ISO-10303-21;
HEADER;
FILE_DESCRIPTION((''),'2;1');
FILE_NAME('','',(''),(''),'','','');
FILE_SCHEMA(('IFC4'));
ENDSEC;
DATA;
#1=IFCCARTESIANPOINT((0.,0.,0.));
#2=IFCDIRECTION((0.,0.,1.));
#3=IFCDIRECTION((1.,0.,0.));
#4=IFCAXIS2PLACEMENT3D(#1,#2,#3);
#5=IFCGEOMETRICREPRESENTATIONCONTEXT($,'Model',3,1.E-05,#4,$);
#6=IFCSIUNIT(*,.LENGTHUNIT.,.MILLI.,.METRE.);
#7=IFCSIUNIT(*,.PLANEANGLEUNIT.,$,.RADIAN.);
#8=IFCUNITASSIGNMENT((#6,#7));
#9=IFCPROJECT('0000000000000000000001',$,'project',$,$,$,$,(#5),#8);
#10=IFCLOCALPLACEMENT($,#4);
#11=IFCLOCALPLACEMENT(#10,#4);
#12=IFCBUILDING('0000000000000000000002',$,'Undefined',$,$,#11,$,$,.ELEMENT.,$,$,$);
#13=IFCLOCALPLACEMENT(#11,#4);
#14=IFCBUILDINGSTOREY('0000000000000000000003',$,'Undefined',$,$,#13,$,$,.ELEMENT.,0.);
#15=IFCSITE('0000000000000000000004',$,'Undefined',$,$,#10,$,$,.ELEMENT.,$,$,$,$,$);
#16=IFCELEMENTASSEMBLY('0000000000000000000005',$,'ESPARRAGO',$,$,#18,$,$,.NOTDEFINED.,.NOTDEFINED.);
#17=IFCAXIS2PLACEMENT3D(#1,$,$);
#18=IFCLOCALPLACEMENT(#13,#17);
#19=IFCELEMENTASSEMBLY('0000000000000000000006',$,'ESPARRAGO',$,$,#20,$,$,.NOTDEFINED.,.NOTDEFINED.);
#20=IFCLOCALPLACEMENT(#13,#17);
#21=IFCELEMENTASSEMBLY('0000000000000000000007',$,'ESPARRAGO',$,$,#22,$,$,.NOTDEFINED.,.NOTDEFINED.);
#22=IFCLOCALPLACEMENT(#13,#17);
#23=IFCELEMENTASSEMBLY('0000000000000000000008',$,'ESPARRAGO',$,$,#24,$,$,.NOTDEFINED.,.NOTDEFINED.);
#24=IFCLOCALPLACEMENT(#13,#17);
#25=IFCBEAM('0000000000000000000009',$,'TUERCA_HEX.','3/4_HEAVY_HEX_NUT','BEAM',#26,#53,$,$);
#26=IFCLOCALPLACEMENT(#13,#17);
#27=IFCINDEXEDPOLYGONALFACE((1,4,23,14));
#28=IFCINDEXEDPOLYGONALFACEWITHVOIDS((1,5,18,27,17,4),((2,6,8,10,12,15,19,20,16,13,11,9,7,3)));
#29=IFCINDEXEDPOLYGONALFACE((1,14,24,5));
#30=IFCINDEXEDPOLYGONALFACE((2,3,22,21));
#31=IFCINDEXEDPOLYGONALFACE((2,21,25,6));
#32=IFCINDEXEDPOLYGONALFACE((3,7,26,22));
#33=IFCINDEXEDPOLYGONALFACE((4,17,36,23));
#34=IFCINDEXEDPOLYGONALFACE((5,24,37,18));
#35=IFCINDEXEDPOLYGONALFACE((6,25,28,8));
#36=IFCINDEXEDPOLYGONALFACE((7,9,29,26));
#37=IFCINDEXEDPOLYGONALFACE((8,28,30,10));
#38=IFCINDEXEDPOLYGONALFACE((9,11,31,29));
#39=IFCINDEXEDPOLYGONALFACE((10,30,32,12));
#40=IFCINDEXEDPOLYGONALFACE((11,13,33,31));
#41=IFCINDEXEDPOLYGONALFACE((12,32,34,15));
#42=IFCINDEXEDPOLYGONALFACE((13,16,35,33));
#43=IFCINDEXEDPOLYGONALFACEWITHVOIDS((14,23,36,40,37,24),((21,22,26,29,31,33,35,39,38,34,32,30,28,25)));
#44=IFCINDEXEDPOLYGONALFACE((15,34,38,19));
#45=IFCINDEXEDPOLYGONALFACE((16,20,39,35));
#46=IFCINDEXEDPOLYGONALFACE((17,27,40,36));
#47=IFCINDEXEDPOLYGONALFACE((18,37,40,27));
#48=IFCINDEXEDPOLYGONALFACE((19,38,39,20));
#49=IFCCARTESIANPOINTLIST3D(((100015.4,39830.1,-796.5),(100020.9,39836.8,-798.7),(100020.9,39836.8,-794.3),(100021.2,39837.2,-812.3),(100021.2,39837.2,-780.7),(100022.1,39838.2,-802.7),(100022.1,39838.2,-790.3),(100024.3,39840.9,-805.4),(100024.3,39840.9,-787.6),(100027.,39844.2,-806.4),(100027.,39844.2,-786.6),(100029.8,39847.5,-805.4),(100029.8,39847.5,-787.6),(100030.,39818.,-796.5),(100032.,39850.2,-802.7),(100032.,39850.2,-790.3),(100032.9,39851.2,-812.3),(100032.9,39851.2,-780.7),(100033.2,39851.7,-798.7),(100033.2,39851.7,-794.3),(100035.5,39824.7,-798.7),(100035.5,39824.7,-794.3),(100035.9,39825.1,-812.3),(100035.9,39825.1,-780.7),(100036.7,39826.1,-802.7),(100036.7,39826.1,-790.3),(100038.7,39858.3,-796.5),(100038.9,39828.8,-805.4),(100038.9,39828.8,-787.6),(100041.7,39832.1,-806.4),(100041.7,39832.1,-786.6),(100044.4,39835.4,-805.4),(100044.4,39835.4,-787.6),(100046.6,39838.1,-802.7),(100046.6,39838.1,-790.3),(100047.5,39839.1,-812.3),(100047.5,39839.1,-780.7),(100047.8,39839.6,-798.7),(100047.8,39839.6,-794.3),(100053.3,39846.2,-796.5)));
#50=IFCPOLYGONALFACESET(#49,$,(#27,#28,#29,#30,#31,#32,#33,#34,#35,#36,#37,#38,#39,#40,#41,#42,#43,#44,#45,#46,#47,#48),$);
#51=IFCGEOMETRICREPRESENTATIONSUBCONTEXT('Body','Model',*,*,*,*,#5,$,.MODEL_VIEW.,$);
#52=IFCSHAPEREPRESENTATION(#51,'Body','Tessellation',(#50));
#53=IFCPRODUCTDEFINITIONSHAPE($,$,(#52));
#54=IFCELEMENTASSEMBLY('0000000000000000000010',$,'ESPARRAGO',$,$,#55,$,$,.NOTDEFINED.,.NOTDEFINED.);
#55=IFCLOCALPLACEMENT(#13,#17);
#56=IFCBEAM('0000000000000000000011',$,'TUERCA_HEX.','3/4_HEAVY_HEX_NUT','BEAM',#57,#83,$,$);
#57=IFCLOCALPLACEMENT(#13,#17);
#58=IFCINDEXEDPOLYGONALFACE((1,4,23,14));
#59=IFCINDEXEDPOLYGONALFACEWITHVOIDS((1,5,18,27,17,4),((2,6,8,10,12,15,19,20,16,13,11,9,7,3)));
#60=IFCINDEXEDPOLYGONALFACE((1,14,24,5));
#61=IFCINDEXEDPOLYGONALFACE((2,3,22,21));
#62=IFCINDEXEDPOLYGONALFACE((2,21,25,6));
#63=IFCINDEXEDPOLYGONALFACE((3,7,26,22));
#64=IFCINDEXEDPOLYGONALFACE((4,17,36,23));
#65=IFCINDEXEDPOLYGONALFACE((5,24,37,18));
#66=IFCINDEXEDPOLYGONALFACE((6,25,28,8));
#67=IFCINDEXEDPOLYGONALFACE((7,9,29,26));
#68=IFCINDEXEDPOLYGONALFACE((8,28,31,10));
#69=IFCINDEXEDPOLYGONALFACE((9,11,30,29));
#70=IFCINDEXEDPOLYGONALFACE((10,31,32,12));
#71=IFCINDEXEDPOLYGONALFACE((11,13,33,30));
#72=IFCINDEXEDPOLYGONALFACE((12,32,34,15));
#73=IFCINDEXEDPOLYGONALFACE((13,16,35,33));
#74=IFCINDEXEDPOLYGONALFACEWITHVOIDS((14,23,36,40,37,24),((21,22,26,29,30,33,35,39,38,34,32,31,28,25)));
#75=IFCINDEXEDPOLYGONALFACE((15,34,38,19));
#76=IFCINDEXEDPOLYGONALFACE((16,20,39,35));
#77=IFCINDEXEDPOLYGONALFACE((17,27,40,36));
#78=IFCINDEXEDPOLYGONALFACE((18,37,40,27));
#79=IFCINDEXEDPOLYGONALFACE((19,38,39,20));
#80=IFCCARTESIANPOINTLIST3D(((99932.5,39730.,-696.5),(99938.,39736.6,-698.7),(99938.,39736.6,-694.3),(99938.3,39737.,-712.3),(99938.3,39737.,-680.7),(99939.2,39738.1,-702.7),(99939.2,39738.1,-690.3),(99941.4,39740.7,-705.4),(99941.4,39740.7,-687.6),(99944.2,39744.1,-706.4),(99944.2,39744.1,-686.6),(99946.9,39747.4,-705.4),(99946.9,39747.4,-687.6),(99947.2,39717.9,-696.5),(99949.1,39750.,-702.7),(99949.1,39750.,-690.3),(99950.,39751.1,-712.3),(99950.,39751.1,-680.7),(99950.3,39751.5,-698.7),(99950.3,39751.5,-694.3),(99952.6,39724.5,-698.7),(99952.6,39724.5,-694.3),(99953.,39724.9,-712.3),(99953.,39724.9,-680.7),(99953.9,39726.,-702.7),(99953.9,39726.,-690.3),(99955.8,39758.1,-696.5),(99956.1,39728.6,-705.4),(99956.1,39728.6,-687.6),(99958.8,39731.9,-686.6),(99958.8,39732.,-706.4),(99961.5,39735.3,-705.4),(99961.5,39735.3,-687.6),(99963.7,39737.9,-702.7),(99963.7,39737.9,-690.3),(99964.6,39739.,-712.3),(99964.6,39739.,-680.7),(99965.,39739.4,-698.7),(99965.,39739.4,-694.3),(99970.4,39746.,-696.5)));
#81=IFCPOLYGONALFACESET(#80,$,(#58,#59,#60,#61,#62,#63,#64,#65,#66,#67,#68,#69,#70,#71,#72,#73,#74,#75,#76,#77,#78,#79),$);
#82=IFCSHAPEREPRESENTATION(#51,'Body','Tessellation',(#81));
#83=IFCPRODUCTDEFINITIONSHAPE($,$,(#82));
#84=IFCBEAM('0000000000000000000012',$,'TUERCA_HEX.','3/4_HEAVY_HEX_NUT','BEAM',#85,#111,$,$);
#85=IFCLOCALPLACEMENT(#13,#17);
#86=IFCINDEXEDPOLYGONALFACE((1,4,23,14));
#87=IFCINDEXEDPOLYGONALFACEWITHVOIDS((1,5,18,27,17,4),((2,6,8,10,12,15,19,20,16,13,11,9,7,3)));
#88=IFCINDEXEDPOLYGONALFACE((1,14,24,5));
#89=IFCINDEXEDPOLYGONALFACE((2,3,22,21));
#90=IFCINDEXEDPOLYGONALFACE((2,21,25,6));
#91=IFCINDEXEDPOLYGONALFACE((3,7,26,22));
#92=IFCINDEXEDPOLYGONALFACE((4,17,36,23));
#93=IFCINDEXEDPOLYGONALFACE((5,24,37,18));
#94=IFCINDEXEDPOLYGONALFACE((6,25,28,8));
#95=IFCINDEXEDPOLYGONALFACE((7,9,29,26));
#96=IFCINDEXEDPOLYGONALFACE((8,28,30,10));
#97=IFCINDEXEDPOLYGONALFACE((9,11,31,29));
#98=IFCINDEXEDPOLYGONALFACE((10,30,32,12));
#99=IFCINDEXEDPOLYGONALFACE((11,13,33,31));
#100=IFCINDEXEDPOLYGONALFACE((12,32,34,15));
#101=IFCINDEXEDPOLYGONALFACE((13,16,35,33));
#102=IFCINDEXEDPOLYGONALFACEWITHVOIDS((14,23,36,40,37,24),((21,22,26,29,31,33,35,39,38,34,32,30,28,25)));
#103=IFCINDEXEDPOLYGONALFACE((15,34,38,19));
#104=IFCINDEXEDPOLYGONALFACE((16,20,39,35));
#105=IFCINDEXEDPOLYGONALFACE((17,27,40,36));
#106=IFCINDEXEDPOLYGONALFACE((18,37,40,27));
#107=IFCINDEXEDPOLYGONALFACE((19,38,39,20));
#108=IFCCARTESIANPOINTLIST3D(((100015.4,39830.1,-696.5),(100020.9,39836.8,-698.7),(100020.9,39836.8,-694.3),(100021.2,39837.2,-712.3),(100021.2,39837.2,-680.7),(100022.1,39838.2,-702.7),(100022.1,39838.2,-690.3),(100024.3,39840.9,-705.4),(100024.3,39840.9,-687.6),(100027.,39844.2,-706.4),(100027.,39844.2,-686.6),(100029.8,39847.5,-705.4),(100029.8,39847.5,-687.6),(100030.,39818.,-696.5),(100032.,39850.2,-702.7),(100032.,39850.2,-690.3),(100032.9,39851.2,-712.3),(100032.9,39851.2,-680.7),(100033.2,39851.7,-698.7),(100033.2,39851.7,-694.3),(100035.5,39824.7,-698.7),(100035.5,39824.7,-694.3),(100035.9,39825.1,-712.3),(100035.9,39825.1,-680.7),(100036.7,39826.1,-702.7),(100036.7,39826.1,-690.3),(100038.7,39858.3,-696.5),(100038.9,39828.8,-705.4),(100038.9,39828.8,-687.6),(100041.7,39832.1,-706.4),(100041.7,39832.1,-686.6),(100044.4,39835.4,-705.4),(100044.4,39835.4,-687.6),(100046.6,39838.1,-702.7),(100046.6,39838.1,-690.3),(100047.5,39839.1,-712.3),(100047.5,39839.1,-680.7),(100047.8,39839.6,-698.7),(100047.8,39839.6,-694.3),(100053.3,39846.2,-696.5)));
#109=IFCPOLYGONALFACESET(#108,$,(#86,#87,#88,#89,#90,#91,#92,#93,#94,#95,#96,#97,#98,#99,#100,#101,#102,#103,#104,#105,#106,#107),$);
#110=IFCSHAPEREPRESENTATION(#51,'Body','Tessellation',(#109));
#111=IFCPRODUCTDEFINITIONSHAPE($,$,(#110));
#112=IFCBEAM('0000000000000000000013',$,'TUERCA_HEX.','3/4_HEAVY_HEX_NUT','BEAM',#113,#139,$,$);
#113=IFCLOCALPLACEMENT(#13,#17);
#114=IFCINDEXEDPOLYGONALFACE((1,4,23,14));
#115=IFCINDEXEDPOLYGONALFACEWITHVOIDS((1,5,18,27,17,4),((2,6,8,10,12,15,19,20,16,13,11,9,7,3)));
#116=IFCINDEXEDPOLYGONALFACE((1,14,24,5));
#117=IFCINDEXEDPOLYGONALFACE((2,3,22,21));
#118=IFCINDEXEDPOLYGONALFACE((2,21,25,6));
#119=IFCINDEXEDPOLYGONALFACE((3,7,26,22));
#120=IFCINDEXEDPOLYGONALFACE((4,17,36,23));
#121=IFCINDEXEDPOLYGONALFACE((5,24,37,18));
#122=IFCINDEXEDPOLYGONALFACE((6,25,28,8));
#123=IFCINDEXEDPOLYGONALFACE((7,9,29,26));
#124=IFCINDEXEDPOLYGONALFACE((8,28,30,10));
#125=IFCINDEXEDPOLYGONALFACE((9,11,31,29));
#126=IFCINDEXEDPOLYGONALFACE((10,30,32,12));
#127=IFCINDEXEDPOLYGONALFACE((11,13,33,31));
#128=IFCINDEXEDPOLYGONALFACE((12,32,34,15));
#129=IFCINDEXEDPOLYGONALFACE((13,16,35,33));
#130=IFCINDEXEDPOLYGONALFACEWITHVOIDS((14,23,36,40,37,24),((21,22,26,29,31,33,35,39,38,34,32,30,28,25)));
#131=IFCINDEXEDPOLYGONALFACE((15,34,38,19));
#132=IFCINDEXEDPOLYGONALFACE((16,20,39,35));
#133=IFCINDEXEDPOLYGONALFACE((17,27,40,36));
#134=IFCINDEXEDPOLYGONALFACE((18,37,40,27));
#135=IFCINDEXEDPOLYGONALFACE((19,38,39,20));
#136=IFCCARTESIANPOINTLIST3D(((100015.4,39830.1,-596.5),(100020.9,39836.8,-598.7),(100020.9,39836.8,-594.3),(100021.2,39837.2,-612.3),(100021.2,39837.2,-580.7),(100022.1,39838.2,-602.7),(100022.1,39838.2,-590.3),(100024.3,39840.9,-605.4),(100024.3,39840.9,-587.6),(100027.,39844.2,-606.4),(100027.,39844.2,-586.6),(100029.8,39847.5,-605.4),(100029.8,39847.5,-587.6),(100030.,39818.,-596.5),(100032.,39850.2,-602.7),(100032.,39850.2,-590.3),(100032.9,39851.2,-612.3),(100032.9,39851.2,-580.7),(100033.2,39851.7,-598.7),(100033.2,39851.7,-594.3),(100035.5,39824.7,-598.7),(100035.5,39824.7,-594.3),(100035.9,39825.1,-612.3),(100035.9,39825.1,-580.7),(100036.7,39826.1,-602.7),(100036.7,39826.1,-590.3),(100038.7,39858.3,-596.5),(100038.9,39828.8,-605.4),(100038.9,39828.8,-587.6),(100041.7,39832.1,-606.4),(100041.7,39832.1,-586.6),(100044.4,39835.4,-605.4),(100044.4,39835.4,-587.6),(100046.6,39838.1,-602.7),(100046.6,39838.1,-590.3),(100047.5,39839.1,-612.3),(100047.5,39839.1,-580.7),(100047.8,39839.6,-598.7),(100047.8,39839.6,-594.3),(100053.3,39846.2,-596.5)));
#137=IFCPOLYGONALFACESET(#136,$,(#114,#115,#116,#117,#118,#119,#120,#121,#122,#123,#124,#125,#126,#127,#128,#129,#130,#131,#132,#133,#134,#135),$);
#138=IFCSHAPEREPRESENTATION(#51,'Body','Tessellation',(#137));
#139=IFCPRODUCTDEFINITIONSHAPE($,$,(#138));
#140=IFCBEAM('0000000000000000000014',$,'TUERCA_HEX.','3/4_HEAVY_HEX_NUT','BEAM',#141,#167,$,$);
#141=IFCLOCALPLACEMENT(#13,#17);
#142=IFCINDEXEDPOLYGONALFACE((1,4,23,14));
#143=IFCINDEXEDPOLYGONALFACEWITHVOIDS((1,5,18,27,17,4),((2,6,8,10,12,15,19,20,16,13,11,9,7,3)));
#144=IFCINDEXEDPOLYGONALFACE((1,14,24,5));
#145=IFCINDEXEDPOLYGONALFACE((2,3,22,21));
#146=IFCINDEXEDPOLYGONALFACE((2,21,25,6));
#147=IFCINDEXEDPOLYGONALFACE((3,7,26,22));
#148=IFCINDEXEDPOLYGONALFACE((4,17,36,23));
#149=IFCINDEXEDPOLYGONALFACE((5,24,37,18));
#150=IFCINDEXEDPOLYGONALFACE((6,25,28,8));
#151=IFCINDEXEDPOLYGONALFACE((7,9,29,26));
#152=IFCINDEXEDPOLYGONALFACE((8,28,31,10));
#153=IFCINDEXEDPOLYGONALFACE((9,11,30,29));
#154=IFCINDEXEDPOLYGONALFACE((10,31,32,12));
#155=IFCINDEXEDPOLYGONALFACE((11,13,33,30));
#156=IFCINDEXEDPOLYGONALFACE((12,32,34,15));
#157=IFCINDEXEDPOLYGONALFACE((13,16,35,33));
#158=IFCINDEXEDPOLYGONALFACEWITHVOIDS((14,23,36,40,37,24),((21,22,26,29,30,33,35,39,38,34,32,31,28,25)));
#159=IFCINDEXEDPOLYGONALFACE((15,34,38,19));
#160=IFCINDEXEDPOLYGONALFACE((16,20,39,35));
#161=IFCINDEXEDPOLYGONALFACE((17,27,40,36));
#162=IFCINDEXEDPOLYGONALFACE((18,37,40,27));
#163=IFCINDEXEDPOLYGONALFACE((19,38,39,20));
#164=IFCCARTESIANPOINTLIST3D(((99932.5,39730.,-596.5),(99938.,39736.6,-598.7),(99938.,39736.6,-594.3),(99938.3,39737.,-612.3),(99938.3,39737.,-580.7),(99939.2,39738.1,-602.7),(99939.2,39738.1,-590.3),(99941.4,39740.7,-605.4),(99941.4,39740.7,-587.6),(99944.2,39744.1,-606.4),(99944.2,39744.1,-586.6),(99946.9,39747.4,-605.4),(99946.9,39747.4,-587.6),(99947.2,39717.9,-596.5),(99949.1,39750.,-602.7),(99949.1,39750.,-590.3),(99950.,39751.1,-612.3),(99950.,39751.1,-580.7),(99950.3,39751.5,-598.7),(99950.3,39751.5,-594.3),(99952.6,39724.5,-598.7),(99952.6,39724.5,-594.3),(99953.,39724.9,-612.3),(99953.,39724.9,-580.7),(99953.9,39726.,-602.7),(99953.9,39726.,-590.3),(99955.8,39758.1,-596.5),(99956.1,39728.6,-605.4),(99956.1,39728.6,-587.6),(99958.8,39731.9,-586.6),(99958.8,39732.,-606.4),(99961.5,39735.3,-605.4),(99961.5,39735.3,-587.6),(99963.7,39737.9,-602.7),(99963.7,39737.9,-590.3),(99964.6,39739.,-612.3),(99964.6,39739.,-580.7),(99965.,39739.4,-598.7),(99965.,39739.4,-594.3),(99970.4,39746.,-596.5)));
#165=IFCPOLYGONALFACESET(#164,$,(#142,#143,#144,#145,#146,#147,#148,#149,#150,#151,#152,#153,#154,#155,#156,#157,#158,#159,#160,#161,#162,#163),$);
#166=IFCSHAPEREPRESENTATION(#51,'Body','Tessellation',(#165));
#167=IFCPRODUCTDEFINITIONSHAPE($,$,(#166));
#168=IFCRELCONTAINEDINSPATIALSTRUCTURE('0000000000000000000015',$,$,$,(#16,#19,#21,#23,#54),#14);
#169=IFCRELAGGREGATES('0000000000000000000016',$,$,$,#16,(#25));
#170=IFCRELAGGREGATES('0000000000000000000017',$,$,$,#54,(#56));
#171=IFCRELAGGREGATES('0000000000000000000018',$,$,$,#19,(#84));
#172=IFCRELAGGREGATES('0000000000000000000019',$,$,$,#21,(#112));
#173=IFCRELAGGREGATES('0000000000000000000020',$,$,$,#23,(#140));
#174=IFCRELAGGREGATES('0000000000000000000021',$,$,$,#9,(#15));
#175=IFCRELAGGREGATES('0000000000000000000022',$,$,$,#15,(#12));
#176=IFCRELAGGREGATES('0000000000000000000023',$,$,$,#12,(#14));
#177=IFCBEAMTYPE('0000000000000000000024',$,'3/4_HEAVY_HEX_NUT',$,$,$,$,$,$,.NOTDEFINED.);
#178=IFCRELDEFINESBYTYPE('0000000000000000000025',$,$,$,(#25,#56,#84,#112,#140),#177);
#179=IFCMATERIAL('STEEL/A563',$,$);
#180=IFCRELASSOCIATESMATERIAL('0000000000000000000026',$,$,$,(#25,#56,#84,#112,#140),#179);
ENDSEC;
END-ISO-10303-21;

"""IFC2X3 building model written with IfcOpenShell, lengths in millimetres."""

from ifc_helpers import new_model, si_unit, frame, origin_with_axes, place, context, subcontext, project, spatial, polyline, outline, extrude, material, type_object, element, aggregate, save


model = new_model("IFC2X3")

# Units and contexts
model_context = context("Model", 3, precision=1e-05, world=origin_with_axes())
body_context = subcontext(model_context, "Body", "Model", "MODEL_VIEW")
ifc_project = project(units=[si_unit("LENGTHUNIT", "METRE", prefix="MILLI"), si_unit("PLANEANGLEUNIT", "RADIAN")], contexts=[model_context])

# Site, building, storey
site_placement = place(None, origin_with_axes())
site = spatial("IfcSite", under=ifc_project, at=site_placement, Name="Undefined", CompositionType="ELEMENT")
building_placement = place(site_placement, origin_with_axes())
building = spatial("IfcBuilding", under=site, at=building_placement, Name="Undefined", CompositionType="ELEMENT")
storey_placement = place(building_placement, origin_with_axes())
storey = spatial("IfcBuildingStorey", under=building, at=storey_placement, Name="Undefined", CompositionType="ELEMENT", Elevation=0.0)

# Element assemblies
assembly_1_placement = place(storey_placement, origin_with_axes())
assembly_1 = element("IfcElementAssembly", 1, at=assembly_1_placement, inside=storey, Name="ESPARRAGO", AssemblyPlace="NOTDEFINED", PredefinedType="NOTDEFINED")
assembly_2_placement = place(storey_placement, origin_with_axes())
assembly_2 = element("IfcElementAssembly", 2, at=assembly_2_placement, inside=storey, Name="ESPARRAGO", AssemblyPlace="NOTDEFINED", PredefinedType="NOTDEFINED")
assembly_3_placement = place(storey_placement, origin_with_axes())
assembly_3 = element("IfcElementAssembly", 3, at=assembly_3_placement, inside=storey, Name="ESPARRAGO", AssemblyPlace="NOTDEFINED", PredefinedType="NOTDEFINED")
assembly_4_placement = place(storey_placement, origin_with_axes())
assembly_4 = element("IfcElementAssembly", 4, at=assembly_4_placement, inside=storey, Name="ESPARRAGO", AssemblyPlace="NOTDEFINED", PredefinedType="NOTDEFINED")

# Shared definitions
ifc_material_1 = material(Name="STEEL/A563")
beam_type_1 = type_object("IfcBeamType", Name="3/4_HEAVY_HEX_NUT", PredefinedType="NOTDEFINED")

# Beam
beam_1_placement = place(assembly_1_placement, frame((100027.0, 39844.2, -796.5), z_axis=(0.000012, -0.00001, 1.0), x_axis=(0.7704, -0.637561, -0.000016)))
beam_1 = element("IfcBeam", 5, at=beam_1_placement, type_object=beam_type_1, material=ifc_material_1, Name="TUERCA_HEX.", Description="3/4_HEAVY_HEX_NUT", ObjectType="BEAM", context=body_context, shape_type="SweptSolid", body=[
    extrude(outline(polyline([(9.1, -15.8), (-9.1, -15.8), (-18.3, 0.0), (-9.1, 15.8), (9.1, 15.8), (18.3, 0.0), (9.1, -15.8)]), holes=[polyline([(-4.3, 8.9), (-7.8, 6.2), (-9.7, 2.2), (-9.7, -2.2), (-7.8, -6.2), (-4.3, -8.9), (0.0, -9.9), (4.3, -8.9), (7.8, -6.2), (9.7, -2.2), (9.7, 2.2), (7.8, 6.2), (4.3, 8.9), (0.0, 9.9), (-4.3, 8.9)])]), frame((19.0, 0.0, 0.0), z_axis=(-1.0, 0.0, 0.0), x_axis=(0.0, -1.0, 0.0)), (0.0, 0.0, 1.0), 19.0),
])

# Element assembly, beam
assembly_5_placement = place(storey_placement, origin_with_axes())
assembly_5 = element("IfcElementAssembly", 6, at=assembly_5_placement, inside=storey, Name="ESPARRAGO", AssemblyPlace="NOTDEFINED", PredefinedType="NOTDEFINED")
beam_2_placement = place(assembly_5_placement, frame((99944.2, 39744.1, -696.5), z_axis=(0.000012, -0.00001, 1.0), x_axis=(0.7704, -0.637561, -0.000016)))
beam_2 = element("IfcBeam", 7, at=beam_2_placement, type_object=beam_type_1, material=ifc_material_1, Name="TUERCA_HEX.", Description="3/4_HEAVY_HEX_NUT", ObjectType="BEAM", context=body_context, shape_type="SweptSolid", body=[
    extrude(outline(polyline([(9.1, -15.8), (-9.1, -15.8), (-18.3, 0.0), (-9.1, 15.8), (9.1, 15.8), (18.3, 0.0), (9.1, -15.8)]), holes=[polyline([(-4.3, 8.9), (-7.8, 6.2), (-9.7, 2.2), (-9.7, -2.2), (-7.8, -6.2), (-4.3, -8.9), (0.0, -9.9), (4.3, -8.9), (7.8, -6.2), (9.7, -2.2), (9.7, 2.2), (7.8, 6.2), (4.3, 8.9), (0.0, 9.9), (-4.3, 8.9)])]), frame((19.0, 0.0, 0.0), z_axis=(-1.0, 0.0, 0.0), x_axis=(0.0, -1.0, 0.0)), (0.0, 0.0, 1.0), 19.0),
])

# Beams
beam_3_placement = place(assembly_2_placement, frame((100027.0, 39844.2, -696.5), z_axis=(0.000012, -0.00001, 1.0), x_axis=(0.7704, -0.637561, -0.000016)))
beam_3 = element("IfcBeam", 8, at=beam_3_placement, type_object=beam_type_1, material=ifc_material_1, Name="TUERCA_HEX.", Description="3/4_HEAVY_HEX_NUT", ObjectType="BEAM", context=body_context, shape_type="SweptSolid", body=[
    extrude(outline(polyline([(9.1, -15.8), (-9.1, -15.8), (-18.3, 0.0), (-9.1, 15.8), (9.1, 15.8), (18.3, 0.0), (9.1, -15.8)]), holes=[polyline([(-4.3, 8.9), (-7.8, 6.2), (-9.7, 2.2), (-9.7, -2.2), (-7.8, -6.2), (-4.3, -8.9), (0.0, -9.9), (4.3, -8.9), (7.8, -6.2), (9.7, -2.2), (9.7, 2.2), (7.8, 6.2), (4.3, 8.9), (0.0, 9.9), (-4.3, 8.9)])]), frame((19.0, 0.0, 0.0), z_axis=(-1.0, 0.0, 0.0), x_axis=(0.0, -1.0, 0.0)), (0.0, 0.0, 1.0), 19.0),
])
beam_4_placement = place(assembly_3_placement, frame((100027.0, 39844.2, -596.5), z_axis=(0.000012, -0.00001, 1.0), x_axis=(0.7704, -0.637561, -0.000016)))
beam_4 = element("IfcBeam", 9, at=beam_4_placement, type_object=beam_type_1, material=ifc_material_1, Name="TUERCA_HEX.", Description="3/4_HEAVY_HEX_NUT", ObjectType="BEAM", context=body_context, shape_type="SweptSolid", body=[
    extrude(outline(polyline([(9.1, -15.8), (-9.1, -15.8), (-18.3, 0.0), (-9.1, 15.8), (9.1, 15.8), (18.3, 0.0), (9.1, -15.8)]), holes=[polyline([(-4.3, 8.9), (-7.8, 6.2), (-9.7, 2.2), (-9.7, -2.2), (-7.8, -6.2), (-4.3, -8.9), (0.0, -9.9), (4.3, -8.9), (7.8, -6.2), (9.7, -2.2), (9.7, 2.2), (7.8, 6.2), (4.3, 8.9), (0.0, 9.9), (-4.3, 8.9)])]), frame((19.0, 0.0, 0.0), z_axis=(-1.0, 0.0, 0.0), x_axis=(0.0, -1.0, 0.0)), (0.0, 0.0, 1.0), 19.0),
])
beam_5_placement = place(assembly_4_placement, frame((99944.2, 39744.1, -596.5), z_axis=(0.000012, -0.00001, 1.0), x_axis=(0.7704, -0.637561, -0.000016)))
beam_5 = element("IfcBeam", 10, at=beam_5_placement, type_object=beam_type_1, material=ifc_material_1, Name="TUERCA_HEX.", Description="3/4_HEAVY_HEX_NUT", ObjectType="BEAM", context=body_context, shape_type="SweptSolid", body=[
    extrude(outline(polyline([(9.1, -15.8), (-9.1, -15.8), (-18.3, 0.0), (-9.1, 15.8), (9.1, 15.8), (18.3, 0.0), (9.1, -15.8)]), holes=[polyline([(-4.3, 8.9), (-7.8, 6.2), (-9.7, 2.2), (-9.7, -2.2), (-7.8, -6.2), (-4.3, -8.9), (0.0, -9.9), (4.3, -8.9), (7.8, -6.2), (9.7, -2.2), (9.7, 2.2), (7.8, 6.2), (4.3, 8.9), (0.0, 9.9), (-4.3, 8.9)])]), frame((19.0, 0.0, 0.0), z_axis=(-1.0, 0.0, 0.0), x_axis=(0.0, -1.0, 0.0)), (0.0, 0.0, 1.0), 19.0),
])
aggregate(assembly_1, [beam_1])
aggregate(assembly_5, [beam_2])
aggregate(assembly_2, [beam_3])
aggregate(assembly_3, [beam_4])
aggregate(assembly_4, [beam_5])

save(model, "model.ifc")
